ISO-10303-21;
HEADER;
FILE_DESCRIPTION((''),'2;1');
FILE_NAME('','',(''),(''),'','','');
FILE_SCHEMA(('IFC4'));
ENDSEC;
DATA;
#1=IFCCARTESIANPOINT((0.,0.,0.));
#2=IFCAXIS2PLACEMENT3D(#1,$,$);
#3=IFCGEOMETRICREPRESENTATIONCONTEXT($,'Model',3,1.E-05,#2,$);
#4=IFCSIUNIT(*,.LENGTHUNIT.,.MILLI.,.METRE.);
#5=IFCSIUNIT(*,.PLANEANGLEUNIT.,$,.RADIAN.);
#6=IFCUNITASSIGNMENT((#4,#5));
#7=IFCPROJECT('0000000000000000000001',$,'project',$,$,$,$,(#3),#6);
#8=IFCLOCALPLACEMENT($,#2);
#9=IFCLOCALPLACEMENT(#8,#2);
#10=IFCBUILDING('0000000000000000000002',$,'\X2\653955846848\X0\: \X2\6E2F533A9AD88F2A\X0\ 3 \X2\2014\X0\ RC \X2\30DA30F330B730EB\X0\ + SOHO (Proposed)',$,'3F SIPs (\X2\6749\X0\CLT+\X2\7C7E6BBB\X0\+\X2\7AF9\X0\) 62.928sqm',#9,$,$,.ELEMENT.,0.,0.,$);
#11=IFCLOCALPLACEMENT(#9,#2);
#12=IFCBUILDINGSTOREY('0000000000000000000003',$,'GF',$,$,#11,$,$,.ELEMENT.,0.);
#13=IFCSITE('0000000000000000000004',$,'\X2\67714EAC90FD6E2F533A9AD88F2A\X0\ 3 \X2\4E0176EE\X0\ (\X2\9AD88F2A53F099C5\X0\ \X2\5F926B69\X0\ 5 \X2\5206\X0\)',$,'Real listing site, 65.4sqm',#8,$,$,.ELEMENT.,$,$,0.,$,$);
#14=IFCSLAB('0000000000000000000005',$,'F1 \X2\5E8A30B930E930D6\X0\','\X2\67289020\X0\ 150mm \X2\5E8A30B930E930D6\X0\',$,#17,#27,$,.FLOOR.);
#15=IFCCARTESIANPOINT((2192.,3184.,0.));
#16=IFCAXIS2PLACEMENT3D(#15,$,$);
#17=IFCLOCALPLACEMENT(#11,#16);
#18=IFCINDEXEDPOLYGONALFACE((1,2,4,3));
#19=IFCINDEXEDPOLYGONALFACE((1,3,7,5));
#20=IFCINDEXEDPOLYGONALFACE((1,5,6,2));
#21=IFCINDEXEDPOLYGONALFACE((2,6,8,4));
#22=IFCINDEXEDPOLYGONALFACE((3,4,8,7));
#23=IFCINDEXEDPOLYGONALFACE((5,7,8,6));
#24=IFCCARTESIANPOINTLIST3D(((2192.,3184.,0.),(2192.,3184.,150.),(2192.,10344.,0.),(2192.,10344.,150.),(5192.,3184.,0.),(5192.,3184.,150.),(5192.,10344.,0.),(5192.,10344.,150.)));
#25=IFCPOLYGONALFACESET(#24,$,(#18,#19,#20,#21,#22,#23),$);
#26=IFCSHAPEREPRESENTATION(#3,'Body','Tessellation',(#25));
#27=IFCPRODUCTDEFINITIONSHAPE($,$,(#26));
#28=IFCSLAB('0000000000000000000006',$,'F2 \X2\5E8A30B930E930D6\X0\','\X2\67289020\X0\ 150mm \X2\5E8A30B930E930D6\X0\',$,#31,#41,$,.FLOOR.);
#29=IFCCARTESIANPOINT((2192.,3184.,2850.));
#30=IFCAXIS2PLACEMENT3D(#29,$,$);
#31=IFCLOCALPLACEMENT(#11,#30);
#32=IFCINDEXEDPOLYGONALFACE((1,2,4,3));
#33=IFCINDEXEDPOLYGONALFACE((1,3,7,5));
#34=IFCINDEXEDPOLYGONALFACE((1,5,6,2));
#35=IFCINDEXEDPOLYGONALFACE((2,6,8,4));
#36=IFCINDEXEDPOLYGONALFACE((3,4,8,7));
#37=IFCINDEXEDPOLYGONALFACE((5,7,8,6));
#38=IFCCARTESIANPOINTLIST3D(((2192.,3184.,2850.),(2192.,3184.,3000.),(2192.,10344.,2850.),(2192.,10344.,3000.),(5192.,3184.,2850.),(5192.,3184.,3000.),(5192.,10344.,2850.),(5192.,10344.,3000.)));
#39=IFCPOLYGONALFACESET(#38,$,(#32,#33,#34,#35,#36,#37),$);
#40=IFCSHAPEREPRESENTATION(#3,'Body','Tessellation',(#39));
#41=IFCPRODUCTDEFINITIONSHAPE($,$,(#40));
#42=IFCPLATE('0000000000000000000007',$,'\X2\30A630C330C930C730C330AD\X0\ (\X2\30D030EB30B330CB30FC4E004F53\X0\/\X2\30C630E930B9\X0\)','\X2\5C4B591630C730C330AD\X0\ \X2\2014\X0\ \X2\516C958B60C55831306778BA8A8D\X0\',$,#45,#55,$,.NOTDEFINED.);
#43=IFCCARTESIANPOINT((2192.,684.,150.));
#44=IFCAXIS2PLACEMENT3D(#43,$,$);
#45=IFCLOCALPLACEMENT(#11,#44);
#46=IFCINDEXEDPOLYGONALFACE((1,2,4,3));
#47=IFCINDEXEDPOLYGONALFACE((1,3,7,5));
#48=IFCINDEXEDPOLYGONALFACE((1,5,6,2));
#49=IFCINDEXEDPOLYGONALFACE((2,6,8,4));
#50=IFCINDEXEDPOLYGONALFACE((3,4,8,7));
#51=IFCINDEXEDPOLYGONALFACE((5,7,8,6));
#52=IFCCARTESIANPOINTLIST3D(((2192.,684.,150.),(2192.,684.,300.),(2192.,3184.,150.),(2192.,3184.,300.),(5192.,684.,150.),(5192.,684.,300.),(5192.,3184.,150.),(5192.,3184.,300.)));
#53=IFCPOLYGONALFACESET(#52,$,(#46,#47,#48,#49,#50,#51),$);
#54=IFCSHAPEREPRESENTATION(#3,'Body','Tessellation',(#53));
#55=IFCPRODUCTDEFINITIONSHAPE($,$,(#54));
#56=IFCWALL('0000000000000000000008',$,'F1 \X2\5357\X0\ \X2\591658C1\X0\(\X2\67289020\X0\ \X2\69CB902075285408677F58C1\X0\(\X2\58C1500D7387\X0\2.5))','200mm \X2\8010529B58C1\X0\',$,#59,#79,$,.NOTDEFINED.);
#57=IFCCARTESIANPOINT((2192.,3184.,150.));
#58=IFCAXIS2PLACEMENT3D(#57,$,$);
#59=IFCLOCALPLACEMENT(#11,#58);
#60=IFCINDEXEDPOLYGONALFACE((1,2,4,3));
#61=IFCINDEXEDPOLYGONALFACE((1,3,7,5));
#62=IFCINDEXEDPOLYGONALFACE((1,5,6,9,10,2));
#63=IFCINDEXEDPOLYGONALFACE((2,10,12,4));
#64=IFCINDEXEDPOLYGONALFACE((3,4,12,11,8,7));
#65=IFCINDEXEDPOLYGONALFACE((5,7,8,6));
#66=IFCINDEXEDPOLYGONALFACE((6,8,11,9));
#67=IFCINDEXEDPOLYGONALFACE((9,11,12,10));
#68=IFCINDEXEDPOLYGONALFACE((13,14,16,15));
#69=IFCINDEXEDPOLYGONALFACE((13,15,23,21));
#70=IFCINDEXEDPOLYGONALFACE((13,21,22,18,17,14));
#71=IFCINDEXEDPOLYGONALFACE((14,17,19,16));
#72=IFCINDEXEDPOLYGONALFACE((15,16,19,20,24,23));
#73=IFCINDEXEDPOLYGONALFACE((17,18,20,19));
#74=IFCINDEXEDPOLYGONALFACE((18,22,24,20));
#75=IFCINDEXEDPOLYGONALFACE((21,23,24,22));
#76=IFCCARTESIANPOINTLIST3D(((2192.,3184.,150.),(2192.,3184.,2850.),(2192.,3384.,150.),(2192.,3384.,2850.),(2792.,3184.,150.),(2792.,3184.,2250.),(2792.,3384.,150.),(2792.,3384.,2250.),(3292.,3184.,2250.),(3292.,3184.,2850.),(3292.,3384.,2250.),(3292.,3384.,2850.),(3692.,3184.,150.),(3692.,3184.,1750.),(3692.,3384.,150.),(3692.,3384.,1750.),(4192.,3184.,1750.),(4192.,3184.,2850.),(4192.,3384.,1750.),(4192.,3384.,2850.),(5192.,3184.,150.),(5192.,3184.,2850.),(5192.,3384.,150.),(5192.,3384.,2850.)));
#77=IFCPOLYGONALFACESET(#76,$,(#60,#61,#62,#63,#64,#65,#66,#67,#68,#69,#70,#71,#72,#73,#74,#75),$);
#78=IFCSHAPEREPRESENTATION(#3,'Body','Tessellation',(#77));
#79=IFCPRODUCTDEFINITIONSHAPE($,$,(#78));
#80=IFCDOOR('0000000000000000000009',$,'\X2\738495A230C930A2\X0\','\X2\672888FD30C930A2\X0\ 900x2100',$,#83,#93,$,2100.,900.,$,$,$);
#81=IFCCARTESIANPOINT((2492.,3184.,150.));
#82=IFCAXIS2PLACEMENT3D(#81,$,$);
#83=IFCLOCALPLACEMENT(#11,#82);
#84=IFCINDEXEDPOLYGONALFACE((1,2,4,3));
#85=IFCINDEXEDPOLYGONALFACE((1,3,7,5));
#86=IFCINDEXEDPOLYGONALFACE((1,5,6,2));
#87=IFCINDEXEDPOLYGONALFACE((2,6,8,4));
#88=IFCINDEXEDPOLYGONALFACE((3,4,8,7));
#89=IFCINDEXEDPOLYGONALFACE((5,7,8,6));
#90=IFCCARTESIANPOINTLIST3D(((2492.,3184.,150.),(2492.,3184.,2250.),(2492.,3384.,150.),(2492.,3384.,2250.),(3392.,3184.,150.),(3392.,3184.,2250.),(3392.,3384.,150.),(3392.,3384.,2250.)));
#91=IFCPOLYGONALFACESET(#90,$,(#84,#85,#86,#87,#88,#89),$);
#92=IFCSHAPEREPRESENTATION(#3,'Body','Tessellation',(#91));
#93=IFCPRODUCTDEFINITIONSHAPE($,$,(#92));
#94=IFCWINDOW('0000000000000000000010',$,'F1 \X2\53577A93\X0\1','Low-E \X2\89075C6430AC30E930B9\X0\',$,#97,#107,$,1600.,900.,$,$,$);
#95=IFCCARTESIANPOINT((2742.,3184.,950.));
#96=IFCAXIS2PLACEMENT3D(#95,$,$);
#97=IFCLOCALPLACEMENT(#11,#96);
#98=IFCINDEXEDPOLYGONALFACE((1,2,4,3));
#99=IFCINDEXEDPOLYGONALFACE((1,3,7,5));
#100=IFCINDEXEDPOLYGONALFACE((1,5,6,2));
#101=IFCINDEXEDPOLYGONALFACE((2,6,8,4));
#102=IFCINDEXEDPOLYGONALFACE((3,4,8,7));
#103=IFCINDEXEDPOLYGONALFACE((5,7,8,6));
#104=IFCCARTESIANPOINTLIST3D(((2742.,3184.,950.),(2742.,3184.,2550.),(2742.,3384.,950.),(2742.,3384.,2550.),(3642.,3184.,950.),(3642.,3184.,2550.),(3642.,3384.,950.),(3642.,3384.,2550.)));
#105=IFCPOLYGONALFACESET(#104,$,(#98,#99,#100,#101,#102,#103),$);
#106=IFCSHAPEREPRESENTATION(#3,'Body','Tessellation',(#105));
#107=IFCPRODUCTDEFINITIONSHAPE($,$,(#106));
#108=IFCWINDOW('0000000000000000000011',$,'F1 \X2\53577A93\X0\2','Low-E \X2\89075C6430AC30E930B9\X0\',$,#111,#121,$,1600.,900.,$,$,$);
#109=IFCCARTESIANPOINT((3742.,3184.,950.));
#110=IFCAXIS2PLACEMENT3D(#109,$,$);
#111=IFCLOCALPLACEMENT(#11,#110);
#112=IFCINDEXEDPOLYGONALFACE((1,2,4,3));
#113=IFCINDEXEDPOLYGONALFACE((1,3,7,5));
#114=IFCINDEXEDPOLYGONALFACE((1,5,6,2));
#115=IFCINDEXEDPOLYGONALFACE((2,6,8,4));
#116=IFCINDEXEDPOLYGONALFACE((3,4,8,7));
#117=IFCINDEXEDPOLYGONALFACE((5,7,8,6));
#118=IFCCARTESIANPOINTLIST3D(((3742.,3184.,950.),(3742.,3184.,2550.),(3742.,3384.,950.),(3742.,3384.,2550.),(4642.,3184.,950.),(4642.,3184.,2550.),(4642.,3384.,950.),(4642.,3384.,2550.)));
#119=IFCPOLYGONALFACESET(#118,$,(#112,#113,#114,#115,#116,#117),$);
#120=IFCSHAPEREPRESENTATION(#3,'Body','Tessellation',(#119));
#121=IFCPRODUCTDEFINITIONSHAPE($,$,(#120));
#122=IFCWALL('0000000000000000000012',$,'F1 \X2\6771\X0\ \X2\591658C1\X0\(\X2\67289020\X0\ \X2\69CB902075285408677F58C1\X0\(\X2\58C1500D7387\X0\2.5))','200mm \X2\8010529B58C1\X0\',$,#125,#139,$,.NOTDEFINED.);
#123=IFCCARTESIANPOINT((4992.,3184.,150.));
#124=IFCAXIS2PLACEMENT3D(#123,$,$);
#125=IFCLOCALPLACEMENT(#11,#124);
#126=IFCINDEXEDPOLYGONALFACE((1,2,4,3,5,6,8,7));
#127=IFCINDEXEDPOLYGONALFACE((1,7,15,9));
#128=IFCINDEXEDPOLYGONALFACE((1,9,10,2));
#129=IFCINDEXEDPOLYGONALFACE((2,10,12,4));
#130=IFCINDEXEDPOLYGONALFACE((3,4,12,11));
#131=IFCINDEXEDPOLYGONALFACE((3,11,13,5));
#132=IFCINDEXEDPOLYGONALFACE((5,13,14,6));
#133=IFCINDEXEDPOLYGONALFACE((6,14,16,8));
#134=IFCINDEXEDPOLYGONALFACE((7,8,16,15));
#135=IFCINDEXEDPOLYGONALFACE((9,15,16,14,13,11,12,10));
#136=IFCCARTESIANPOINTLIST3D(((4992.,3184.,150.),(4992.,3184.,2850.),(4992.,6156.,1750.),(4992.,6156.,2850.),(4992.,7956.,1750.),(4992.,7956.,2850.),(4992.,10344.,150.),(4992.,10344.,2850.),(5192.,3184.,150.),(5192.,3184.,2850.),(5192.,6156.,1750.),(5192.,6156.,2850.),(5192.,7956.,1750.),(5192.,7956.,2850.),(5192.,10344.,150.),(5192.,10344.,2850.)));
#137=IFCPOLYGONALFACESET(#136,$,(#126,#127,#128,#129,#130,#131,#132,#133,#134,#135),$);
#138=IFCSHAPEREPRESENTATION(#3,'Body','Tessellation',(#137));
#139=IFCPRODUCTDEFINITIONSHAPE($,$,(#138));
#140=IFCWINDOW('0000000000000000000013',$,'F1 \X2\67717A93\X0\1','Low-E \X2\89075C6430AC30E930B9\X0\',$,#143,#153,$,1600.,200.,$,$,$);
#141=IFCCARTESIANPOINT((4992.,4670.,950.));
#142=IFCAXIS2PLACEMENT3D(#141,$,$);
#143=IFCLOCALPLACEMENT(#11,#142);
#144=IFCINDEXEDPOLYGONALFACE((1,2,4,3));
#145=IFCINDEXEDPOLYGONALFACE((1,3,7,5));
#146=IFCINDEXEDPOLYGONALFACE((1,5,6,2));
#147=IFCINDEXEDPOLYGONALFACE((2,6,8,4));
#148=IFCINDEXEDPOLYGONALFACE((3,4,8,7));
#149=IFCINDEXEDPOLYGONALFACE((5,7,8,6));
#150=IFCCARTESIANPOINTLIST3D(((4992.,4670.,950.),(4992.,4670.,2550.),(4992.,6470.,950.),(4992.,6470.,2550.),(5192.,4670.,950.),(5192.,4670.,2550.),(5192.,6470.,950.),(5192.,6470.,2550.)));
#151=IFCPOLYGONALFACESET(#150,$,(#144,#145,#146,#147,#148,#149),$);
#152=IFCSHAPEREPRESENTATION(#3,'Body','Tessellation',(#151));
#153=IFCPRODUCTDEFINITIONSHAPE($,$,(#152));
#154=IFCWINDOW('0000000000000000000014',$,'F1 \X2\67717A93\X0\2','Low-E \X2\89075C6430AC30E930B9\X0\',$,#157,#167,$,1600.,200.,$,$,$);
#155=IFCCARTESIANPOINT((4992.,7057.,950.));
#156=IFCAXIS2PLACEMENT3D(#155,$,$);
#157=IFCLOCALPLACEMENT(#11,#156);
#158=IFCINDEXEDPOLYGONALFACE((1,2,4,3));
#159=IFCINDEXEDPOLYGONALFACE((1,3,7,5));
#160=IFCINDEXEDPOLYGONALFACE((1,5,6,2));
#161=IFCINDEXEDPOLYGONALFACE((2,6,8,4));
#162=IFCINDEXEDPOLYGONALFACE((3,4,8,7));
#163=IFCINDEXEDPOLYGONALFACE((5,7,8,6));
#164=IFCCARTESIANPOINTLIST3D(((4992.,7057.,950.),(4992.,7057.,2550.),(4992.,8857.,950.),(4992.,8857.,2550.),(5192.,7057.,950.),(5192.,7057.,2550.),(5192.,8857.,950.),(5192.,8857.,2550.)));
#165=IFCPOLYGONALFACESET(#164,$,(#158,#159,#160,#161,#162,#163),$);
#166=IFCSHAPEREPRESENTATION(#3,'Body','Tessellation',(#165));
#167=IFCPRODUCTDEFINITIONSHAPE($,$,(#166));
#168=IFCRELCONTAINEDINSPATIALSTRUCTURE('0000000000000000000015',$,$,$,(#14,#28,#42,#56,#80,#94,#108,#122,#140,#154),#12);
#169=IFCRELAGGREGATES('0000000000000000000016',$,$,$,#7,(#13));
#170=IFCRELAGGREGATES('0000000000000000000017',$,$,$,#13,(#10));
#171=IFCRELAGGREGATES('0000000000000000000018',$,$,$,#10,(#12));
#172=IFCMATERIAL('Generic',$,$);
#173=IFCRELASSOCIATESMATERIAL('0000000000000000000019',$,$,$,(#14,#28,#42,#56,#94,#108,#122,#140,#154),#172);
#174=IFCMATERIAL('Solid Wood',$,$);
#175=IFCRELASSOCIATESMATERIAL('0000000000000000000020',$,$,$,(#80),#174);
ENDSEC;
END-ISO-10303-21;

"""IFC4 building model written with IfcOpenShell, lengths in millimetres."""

from ifc_helpers import new_model, si_unit, frame, frame_2d, origin, place, context, project, spatial, rectangle, extrude, material, element, fill, save


model = new_model("IFC4")

# Units and contexts
model_context = context("Model", 3, precision=1e-05, world=origin())
ifc_project = project(units=[si_unit("LENGTHUNIT", "METRE", prefix="MILLI"), si_unit("PLANEANGLEUNIT", "RADIAN")], contexts=[model_context])

# Site, building, storey
site_placement = place(None, origin())
site = spatial("IfcSite", under=ifc_project, at=site_placement, Name="東京都港区高輪 3 丁目 (高輪台駅 徒歩 5 分)", ObjectType="Real listing site, 65.4sqm", CompositionType="ELEMENT", RefElevation=0.0)
building_placement = place(site_placement, origin())
building = spatial("IfcBuilding", under=site, at=building_placement, Name="改善案: 港区高輪 3 — RC ペンシル + SOHO (Proposed)", ObjectType="3F SIPs (杉CLT+籾殻+竹) 62.928sqm", CompositionType="ELEMENT", ElevationOfRefHeight=0.0, ElevationOfTerrain=0.0)
storey_placement = place(building_placement, origin())
storey = spatial("IfcBuildingStorey", under=building, at=storey_placement, Name="GF", CompositionType="ELEMENT", Elevation=0.0)

# Slabs
ifc_material_1 = material(Name="Generic")
slab_1_placement = place(storey_placement, frame((2192.0, 3184.0, 0.0)))
element("IfcSlab", 1, at=slab_1_placement, inside=storey, material=ifc_material_1, Name="F1 床スラブ", Description="木造 150mm 床スラブ", PredefinedType="FLOOR", context=model_context, shape_type="SweptSolid", body=[
    extrude(rectangle(XDim=3000.0, YDim=7160.0, at=frame_2d((1500.0, 3580.0))), frame((2192.0, 3184.0, 0.0)), (0.0, 0.0, 1.0), 150.0),
])
slab_2_placement = place(storey_placement, frame((2192.0, 3184.0, 2850.0)))
element("IfcSlab", 2, at=slab_2_placement, inside=storey, material=ifc_material_1, Name="F2 床スラブ", Description="木造 150mm 床スラブ", PredefinedType="FLOOR", context=model_context, shape_type="SweptSolid", body=[
    extrude(rectangle(XDim=3000.0, YDim=7160.0, at=frame_2d((1500.0, 3580.0))), frame((2192.0, 3184.0, 2850.0)), (0.0, 0.0, 1.0), 150.0),
])

# Plate
plate_placement = place(storey_placement, frame((2192.0, 684.0, 150.0)))
element("IfcPlate", 3, at=plate_placement, inside=storey, material=ifc_material_1, Name="ウッドデッキ (バルコニー一体/テラス)", Description="屋外デッキ — 公開情報で確認", PredefinedType="NOTDEFINED", context=model_context, shape_type="SweptSolid", body=[
    extrude(rectangle(XDim=3000.0, YDim=2500.0, at=frame_2d((1500.0, 1250.0))), frame((2192.0, 684.0, 150.0)), (0.0, 0.0, 1.0), 150.0),
])

# Wall, openings, door, windows
wall_1_placement = place(storey_placement, frame((2192.0, 3184.0, 150.0)))
wall_1 = element("IfcWall", 4, at=wall_1_placement, inside=storey, material=ifc_material_1, Name="F1 南 外壁(木造 構造用合板壁(壁倍率2.5))", Description="200mm 耐力壁", PredefinedType="NOTDEFINED", context=model_context, shape_type="SweptSolid", body=[
    extrude(rectangle(XDim=3000.0, YDim=200.0, at=frame_2d((1500.0, 100.0))), frame((2192.0, 3184.0, 150.0)), (0.0, 0.0, 1.0), 2700.0),
])
opening_1_placement = place(storey_placement, frame((2492.0, 3184.0, 150.0)))
opening_1 = element("IfcOpeningElement", 5, at=opening_1_placement, cuts=wall_1, PredefinedType="NOTDEFINED", context=model_context, shape_type="SweptSolid", body=[
    extrude(rectangle(XDim=900.0, YDim=200.0, at=frame_2d((450.0, 100.0))), frame((2492.0, 3184.0, 150.0)), (0.0, 0.0, 1.0), 2100.0),
])
opening_2_placement = place(storey_placement, frame((2742.0, 3184.0, 950.0)))
opening_2 = element("IfcOpeningElement", 6, at=opening_2_placement, cuts=wall_1, PredefinedType="NOTDEFINED", context=model_context, shape_type="SweptSolid", body=[
    extrude(rectangle(XDim=900.0, YDim=200.0, at=frame_2d((450.0, 100.0))), frame((2742.0, 3184.0, 950.0)), (0.0, 0.0, 1.0), 1600.0),
])
opening_3_placement = place(storey_placement, frame((3742.0, 3184.0, 950.0)))
opening_3 = element("IfcOpeningElement", 7, at=opening_3_placement, cuts=wall_1, PredefinedType="NOTDEFINED", context=model_context, shape_type="SweptSolid", body=[
    extrude(rectangle(XDim=900.0, YDim=200.0, at=frame_2d((450.0, 100.0))), frame((3742.0, 3184.0, 950.0)), (0.0, 0.0, 1.0), 1600.0),
])
ifc_material_2 = material(Name="Solid Wood")
door_placement = place(storey_placement, frame((2492.0, 3184.0, 150.0)))
door = element("IfcDoor", 8, at=door_placement, inside=storey, material=ifc_material_2, Name="玄関ドア", Description="木製ドア 900x2100", OverallHeight=2100.0, OverallWidth=900.0, context=model_context, shape_type="SweptSolid", body=[
    extrude(rectangle(XDim=900.0, YDim=200.0, at=frame_2d((450.0, 100.0))), frame((2492.0, 3184.0, 150.0)), (0.0, 0.0, 1.0), 2100.0),
])
fill(opening_1, door)
window_1_placement = place(storey_placement, frame((2742.0, 3184.0, 950.0)))
window_1 = element("IfcWindow", 9, at=window_1_placement, inside=storey, material=ifc_material_1, Name="F1 南窓1", Description="Low-E 複層ガラス", OverallHeight=1600.0, OverallWidth=900.0, context=model_context, shape_type="SweptSolid", body=[
    extrude(rectangle(XDim=900.0, YDim=200.0, at=frame_2d((450.0, 100.0))), frame((2742.0, 3184.0, 950.0)), (0.0, 0.0, 1.0), 1600.0),
])
fill(opening_2, window_1)
window_2_placement = place(storey_placement, frame((3742.0, 3184.0, 950.0)))
window_2 = element("IfcWindow", 10, at=window_2_placement, inside=storey, material=ifc_material_1, Name="F1 南窓2", Description="Low-E 複層ガラス", OverallHeight=1600.0, OverallWidth=900.0, context=model_context, shape_type="SweptSolid", body=[
    extrude(rectangle(XDim=900.0, YDim=200.0, at=frame_2d((450.0, 100.0))), frame((3742.0, 3184.0, 950.0)), (0.0, 0.0, 1.0), 1600.0),
])
fill(opening_3, window_2)

# Wall, openings, windows
wall_2_placement = place(storey_placement, frame((4992.0, 3184.0, 150.0)))
wall_2 = element("IfcWall", 11, at=wall_2_placement, inside=storey, material=ifc_material_1, Name="F1 東 外壁(木造 構造用合板壁(壁倍率2.5))", Description="200mm 耐力壁", PredefinedType="NOTDEFINED", context=model_context, shape_type="SweptSolid", body=[
    extrude(rectangle(XDim=200.0, YDim=7160.0, at=frame_2d((100.0, 3580.0))), frame((4992.0, 3184.0, 150.0)), (0.0, 0.0, 1.0), 2700.0),
])
opening_4_placement = place(storey_placement, frame((4992.0, 4670.0, 950.0)))
opening_4 = element("IfcOpeningElement", 12, at=opening_4_placement, cuts=wall_2, PredefinedType="NOTDEFINED", context=model_context, shape_type="SweptSolid", body=[
    extrude(rectangle(XDim=200.0, YDim=1800.0, at=frame_2d((100.0, 900.0))), frame((4992.0, 4670.0, 950.0)), (0.0, 0.0, 1.0), 1600.0),
])
opening_5_placement = place(storey_placement, frame((4992.0, 7057.0, 950.0)))
opening_5 = element("IfcOpeningElement", 13, at=opening_5_placement, cuts=wall_2, PredefinedType="NOTDEFINED", context=model_context, shape_type="SweptSolid", body=[
    extrude(rectangle(XDim=200.0, YDim=1800.0, at=frame_2d((100.0, 900.0))), frame((4992.0, 7057.0, 950.0)), (0.0, 0.0, 1.0), 1600.0),
])
window_3_placement = place(storey_placement, frame((4992.0, 4670.0, 950.0)))
window_3 = element("IfcWindow", 14, at=window_3_placement, inside=storey, material=ifc_material_1, Name="F1 東窓1", Description="Low-E 複層ガラス", OverallHeight=1600.0, OverallWidth=200.0, context=model_context, shape_type="SweptSolid", body=[
    extrude(rectangle(XDim=200.0, YDim=1800.0, at=frame_2d((100.0, 900.0))), frame((4992.0, 4670.0, 950.0)), (0.0, 0.0, 1.0), 1600.0),
])
fill(opening_4, window_3)
window_4_placement = place(storey_placement, frame((4992.0, 7057.0, 950.0)))
window_4 = element("IfcWindow", 15, at=window_4_placement, inside=storey, material=ifc_material_1, Name="F1 東窓2", Description="Low-E 複層ガラス", OverallHeight=1600.0, OverallWidth=200.0, context=model_context, shape_type="SweptSolid", body=[
    extrude(rectangle(XDim=200.0, YDim=1800.0, at=frame_2d((100.0, 900.0))), frame((4992.0, 7057.0, 950.0)), (0.0, 0.0, 1.0), 1600.0),
])
fill(opening_5, window_4)

save(model, "model.ifc")
